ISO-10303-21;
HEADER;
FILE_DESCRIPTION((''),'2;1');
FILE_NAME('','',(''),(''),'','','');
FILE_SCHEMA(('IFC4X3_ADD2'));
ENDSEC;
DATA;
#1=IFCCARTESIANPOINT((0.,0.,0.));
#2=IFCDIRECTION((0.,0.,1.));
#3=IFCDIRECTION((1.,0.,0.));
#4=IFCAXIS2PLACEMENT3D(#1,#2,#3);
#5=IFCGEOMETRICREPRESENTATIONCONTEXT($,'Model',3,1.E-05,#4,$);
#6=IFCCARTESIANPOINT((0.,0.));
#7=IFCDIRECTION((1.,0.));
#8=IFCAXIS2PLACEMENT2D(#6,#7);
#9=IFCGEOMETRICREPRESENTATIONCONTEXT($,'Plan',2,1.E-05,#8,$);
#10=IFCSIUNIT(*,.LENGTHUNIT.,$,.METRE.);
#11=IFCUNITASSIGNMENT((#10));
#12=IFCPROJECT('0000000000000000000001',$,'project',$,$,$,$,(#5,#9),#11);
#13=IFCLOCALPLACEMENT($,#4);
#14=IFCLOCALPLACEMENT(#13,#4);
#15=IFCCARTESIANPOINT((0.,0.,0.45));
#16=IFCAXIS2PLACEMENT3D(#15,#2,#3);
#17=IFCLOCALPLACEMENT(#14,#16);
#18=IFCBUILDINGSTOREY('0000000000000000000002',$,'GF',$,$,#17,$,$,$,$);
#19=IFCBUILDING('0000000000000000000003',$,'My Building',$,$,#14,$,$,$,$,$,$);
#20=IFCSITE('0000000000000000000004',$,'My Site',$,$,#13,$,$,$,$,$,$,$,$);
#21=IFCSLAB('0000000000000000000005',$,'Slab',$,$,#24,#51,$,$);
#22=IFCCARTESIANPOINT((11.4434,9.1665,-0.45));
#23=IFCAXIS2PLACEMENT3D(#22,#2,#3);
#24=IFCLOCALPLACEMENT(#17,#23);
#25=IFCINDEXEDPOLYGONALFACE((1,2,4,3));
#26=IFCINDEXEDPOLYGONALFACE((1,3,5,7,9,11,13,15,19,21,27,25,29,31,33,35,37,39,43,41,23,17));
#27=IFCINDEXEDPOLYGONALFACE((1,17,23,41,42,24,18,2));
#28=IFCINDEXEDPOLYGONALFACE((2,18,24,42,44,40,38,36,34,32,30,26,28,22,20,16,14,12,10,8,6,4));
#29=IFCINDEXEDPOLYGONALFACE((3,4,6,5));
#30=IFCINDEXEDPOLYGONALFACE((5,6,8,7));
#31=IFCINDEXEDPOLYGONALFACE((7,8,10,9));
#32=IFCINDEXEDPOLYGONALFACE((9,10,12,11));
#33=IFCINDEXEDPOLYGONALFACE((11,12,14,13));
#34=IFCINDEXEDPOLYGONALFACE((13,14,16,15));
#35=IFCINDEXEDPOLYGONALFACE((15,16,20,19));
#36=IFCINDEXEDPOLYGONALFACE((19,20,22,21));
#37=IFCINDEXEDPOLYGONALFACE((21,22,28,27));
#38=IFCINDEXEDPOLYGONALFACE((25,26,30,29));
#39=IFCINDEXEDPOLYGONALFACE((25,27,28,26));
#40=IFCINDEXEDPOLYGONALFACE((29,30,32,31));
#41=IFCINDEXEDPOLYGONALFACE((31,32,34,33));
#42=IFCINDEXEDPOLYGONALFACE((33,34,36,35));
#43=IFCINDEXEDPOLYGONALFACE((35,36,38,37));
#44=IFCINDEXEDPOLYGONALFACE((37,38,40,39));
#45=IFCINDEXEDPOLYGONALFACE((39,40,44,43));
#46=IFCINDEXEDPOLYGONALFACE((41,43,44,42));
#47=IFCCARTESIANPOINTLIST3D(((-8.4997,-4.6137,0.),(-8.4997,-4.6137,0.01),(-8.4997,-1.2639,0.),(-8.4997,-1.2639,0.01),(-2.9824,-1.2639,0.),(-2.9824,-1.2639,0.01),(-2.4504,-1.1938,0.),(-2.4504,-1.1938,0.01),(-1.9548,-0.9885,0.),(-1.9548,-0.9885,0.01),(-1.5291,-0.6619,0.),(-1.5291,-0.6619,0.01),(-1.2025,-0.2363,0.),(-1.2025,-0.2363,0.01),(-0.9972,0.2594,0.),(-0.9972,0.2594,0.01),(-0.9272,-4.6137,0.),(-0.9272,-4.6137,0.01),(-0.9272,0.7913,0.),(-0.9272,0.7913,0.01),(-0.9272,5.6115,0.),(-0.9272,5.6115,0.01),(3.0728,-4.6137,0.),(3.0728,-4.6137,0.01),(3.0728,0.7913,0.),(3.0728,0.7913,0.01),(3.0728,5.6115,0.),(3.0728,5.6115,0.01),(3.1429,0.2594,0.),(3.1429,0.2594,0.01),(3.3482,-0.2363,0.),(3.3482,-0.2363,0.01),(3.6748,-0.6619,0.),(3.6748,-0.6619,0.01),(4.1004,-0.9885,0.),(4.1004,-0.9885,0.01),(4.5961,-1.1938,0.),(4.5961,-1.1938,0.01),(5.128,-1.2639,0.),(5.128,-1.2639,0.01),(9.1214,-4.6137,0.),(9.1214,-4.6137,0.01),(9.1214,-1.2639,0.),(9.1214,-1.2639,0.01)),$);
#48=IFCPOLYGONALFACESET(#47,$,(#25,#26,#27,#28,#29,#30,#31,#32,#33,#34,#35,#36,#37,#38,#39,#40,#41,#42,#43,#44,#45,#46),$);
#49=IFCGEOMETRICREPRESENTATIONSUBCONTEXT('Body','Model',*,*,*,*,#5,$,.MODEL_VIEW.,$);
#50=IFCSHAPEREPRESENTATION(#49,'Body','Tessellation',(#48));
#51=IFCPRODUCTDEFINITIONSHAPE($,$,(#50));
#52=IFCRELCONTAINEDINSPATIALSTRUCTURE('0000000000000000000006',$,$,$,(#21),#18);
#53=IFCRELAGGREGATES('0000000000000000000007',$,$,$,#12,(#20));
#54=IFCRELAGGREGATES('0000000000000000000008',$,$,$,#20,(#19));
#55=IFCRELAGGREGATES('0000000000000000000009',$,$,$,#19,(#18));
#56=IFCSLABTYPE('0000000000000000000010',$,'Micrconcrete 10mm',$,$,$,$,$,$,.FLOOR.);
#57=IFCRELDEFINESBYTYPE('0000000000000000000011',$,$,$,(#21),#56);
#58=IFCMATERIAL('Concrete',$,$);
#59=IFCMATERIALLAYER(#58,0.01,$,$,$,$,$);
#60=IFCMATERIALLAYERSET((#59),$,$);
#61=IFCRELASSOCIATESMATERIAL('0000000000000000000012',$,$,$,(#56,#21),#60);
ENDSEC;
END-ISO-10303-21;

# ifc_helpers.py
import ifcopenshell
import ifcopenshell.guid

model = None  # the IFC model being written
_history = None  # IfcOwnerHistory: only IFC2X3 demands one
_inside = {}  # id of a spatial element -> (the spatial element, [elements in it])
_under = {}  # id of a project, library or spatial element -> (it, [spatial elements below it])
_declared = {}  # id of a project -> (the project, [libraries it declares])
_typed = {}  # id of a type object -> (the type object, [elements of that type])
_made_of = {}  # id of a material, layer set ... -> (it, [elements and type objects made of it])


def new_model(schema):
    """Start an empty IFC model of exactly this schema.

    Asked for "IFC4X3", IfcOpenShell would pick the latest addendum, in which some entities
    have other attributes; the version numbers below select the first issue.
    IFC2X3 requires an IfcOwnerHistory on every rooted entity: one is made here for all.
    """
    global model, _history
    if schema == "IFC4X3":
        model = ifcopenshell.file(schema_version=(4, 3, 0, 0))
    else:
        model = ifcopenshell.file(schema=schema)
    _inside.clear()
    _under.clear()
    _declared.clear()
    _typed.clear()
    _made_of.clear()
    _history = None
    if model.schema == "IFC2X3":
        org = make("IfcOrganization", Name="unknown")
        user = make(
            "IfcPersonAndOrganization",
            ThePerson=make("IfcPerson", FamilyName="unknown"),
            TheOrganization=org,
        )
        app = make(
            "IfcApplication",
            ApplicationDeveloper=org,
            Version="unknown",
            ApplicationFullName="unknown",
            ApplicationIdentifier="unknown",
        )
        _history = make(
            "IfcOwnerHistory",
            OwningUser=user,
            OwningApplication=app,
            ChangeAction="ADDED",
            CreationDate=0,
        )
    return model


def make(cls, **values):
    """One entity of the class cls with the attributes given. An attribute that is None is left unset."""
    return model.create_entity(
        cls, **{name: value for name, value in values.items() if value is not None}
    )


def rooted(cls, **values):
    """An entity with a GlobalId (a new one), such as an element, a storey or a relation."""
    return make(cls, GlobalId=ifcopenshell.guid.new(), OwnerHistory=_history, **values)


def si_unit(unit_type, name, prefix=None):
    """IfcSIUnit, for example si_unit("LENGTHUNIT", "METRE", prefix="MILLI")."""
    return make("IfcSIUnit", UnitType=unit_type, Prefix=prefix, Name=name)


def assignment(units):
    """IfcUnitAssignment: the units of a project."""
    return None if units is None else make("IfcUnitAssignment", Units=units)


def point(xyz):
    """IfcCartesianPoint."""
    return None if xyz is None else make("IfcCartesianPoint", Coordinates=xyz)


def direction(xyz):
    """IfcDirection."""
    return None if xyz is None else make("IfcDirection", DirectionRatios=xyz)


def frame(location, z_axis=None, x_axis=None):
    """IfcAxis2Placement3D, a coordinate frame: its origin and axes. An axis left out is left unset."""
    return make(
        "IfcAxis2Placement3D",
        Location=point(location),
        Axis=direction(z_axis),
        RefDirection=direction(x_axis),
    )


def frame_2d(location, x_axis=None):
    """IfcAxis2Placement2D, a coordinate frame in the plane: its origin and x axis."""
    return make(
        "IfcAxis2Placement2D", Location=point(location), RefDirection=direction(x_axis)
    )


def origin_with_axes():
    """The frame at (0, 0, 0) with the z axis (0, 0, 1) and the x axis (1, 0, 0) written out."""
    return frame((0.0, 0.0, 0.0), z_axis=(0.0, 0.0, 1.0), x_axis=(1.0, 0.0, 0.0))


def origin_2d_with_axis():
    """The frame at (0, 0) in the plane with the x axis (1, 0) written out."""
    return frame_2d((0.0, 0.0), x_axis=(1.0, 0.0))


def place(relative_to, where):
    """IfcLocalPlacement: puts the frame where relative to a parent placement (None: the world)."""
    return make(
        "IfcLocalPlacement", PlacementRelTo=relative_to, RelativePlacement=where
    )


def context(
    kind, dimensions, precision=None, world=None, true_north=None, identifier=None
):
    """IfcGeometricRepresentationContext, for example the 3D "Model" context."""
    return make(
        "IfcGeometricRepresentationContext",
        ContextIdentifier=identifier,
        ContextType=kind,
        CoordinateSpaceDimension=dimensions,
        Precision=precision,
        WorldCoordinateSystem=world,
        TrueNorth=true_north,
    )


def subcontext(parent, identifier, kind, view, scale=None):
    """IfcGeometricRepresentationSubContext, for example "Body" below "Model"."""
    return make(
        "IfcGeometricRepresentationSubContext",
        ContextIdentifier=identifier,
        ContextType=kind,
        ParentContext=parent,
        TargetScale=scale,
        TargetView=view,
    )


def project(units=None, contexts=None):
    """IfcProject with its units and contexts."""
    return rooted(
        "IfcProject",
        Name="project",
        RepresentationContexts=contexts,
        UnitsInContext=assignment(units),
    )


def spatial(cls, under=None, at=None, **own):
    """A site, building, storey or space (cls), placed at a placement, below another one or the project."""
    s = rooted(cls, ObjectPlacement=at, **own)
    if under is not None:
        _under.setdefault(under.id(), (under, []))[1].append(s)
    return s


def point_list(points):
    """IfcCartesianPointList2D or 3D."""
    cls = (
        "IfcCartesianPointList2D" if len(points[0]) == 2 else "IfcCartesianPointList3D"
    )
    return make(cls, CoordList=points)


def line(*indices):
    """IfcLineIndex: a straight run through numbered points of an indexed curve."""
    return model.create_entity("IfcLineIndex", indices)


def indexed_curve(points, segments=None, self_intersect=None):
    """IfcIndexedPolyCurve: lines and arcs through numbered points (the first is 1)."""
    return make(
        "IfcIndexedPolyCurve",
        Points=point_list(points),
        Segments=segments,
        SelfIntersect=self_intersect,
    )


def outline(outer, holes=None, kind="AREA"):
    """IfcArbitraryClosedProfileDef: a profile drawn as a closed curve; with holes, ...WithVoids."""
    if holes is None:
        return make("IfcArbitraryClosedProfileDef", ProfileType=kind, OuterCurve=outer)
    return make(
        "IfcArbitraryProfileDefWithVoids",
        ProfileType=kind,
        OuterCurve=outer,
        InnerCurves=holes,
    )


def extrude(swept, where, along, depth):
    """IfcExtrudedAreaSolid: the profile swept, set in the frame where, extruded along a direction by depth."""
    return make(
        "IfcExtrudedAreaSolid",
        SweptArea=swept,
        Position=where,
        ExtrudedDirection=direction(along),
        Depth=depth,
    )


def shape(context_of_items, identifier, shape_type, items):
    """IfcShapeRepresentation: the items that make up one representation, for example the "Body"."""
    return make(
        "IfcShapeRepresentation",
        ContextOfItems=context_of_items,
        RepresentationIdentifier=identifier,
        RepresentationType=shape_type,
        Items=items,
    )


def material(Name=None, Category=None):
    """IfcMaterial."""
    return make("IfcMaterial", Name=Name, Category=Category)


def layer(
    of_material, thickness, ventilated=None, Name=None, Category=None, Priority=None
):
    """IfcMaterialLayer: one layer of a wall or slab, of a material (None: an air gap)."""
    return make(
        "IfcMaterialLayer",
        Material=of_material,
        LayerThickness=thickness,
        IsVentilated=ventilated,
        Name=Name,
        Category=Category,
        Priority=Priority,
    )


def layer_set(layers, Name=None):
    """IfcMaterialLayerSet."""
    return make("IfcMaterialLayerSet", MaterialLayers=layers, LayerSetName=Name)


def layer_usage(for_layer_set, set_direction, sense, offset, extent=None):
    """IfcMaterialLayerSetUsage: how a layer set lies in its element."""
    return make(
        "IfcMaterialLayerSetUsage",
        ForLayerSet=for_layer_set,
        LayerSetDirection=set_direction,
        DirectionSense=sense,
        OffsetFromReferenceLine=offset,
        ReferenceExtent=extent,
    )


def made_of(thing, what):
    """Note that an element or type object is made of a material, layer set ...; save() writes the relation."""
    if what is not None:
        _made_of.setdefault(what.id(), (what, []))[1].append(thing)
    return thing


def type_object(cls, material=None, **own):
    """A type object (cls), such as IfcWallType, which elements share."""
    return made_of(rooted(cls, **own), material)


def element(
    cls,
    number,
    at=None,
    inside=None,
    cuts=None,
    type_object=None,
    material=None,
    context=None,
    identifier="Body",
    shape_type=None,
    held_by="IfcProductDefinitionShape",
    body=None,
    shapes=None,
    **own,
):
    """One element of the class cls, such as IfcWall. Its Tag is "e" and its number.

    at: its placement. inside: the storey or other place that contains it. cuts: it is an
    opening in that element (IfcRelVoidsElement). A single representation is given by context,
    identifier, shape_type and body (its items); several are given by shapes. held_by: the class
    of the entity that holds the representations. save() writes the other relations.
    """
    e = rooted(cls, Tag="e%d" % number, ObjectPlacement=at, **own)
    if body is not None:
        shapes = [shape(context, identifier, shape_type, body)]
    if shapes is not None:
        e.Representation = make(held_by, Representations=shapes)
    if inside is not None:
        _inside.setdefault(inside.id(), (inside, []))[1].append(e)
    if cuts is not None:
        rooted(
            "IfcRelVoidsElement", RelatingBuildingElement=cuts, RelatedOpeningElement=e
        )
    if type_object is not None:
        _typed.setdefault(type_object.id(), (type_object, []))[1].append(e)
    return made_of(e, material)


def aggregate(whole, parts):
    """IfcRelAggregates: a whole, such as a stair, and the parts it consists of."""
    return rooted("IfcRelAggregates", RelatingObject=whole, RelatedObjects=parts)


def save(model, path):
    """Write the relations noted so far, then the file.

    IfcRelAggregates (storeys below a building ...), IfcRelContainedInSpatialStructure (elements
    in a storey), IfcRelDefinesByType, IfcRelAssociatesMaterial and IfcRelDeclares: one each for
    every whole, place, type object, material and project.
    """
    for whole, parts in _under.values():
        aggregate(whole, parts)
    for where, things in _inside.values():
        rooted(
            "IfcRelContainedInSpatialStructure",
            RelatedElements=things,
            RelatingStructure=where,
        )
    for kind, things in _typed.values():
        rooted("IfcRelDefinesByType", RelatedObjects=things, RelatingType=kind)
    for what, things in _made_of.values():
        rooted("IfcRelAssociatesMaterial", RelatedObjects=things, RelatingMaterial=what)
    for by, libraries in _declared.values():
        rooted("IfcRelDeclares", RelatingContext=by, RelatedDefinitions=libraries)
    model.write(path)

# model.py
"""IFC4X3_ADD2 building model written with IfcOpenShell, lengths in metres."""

from ifc_helpers import new_model, si_unit, frame, origin_with_axes, origin_2d_with_axis, place, context, subcontext, project, spatial, line, indexed_curve, outline, extrude, material, layer, layer_set, layer_usage, type_object, element, save


model = new_model("IFC4X3_ADD2")

# Units and contexts
model_context = context("Model", 3, precision=1e-05, world=origin_with_axes())
plan_context = context("Plan", 2, precision=1e-05, world=origin_2d_with_axis())
body_context = subcontext(model_context, "Body", "Model", "MODEL_VIEW")
ifc_project = project(units=[si_unit("LENGTHUNIT", "METRE")], contexts=[model_context, plan_context])

# Site, building, storey
site_placement = place(None, origin_with_axes())
site = spatial("IfcSite", under=ifc_project, at=site_placement, Name="My Site")
building_placement = place(site_placement, origin_with_axes())
building = spatial("IfcBuilding", under=site, at=building_placement, Name="My Building")
storey_placement = place(building_placement, frame((0.0, 0.0, 0.45), z_axis=(0.0, 0.0, 1.0), x_axis=(1.0, 0.0, 0.0)))
storey = spatial("IfcBuildingStorey", under=building, at=storey_placement, Name="GF")

# Slab
ifc_material_1 = material(Name="Concrete")
ifc_layer = layer(ifc_material_1, 0.01)
ifc_layer_set = layer_set([ifc_layer])
ifc_layer_usage = layer_usage(ifc_layer_set, "AXIS3", "POSITIVE", 0.0)
slab_type = type_object("IfcSlabType", Name="Micrconcrete 10mm", PredefinedType="FLOOR", material=ifc_layer_set)
slab_placement = place(storey_placement, frame((11.4434, 9.1665, -0.45), z_axis=(0.0, 0.0, 1.0), x_axis=(1.0, 0.0, 0.0)))
element("IfcSlab", 1, at=slab_placement, inside=storey, type_object=slab_type, material=ifc_layer_usage, Name="Slab", context=body_context, shape_type="SweptSolid", body=[
    extrude(outline(indexed_curve([(-0.9272, 0.7913), (-0.9972, 0.2594), (-1.2025, -0.2363), (-1.5291, -0.6619), (-1.9548, -0.9885), (-2.4504, -1.1938), (-2.9824, -1.2639), (-8.4997, -1.2639), (-8.4997, -4.6137), (-0.9272, -4.6137), (3.0728, -4.6137), (9.1214, -4.6137), (9.1214, -1.2639), (5.128, -1.2639), (4.5961, -1.1938), (4.1004, -0.9885), (3.6748, -0.6619), (3.3482, -0.2363), (3.1429, 0.2594), (3.0728, 0.7913), (3.0728, 5.6115), (-0.9272, 5.6115)], segments=[line(14, 13), line(13, 12), line(12, 11), line(11, 10), line(10, 9), line(9, 8), line(8, 7), line(7, 6), line(6, 5), line(5, 4), line(4, 3), line(3, 2), line(2, 1), line(1, 22), line(22, 21), line(21, 20), line(20, 19), line(19, 18), line(18, 17), line(17, 16), line(16, 15), line(15, 14)], self_intersect=False)), None, (0.0, 0.0, 1.0), 0.01),
])

save(model, "model.ifc")
